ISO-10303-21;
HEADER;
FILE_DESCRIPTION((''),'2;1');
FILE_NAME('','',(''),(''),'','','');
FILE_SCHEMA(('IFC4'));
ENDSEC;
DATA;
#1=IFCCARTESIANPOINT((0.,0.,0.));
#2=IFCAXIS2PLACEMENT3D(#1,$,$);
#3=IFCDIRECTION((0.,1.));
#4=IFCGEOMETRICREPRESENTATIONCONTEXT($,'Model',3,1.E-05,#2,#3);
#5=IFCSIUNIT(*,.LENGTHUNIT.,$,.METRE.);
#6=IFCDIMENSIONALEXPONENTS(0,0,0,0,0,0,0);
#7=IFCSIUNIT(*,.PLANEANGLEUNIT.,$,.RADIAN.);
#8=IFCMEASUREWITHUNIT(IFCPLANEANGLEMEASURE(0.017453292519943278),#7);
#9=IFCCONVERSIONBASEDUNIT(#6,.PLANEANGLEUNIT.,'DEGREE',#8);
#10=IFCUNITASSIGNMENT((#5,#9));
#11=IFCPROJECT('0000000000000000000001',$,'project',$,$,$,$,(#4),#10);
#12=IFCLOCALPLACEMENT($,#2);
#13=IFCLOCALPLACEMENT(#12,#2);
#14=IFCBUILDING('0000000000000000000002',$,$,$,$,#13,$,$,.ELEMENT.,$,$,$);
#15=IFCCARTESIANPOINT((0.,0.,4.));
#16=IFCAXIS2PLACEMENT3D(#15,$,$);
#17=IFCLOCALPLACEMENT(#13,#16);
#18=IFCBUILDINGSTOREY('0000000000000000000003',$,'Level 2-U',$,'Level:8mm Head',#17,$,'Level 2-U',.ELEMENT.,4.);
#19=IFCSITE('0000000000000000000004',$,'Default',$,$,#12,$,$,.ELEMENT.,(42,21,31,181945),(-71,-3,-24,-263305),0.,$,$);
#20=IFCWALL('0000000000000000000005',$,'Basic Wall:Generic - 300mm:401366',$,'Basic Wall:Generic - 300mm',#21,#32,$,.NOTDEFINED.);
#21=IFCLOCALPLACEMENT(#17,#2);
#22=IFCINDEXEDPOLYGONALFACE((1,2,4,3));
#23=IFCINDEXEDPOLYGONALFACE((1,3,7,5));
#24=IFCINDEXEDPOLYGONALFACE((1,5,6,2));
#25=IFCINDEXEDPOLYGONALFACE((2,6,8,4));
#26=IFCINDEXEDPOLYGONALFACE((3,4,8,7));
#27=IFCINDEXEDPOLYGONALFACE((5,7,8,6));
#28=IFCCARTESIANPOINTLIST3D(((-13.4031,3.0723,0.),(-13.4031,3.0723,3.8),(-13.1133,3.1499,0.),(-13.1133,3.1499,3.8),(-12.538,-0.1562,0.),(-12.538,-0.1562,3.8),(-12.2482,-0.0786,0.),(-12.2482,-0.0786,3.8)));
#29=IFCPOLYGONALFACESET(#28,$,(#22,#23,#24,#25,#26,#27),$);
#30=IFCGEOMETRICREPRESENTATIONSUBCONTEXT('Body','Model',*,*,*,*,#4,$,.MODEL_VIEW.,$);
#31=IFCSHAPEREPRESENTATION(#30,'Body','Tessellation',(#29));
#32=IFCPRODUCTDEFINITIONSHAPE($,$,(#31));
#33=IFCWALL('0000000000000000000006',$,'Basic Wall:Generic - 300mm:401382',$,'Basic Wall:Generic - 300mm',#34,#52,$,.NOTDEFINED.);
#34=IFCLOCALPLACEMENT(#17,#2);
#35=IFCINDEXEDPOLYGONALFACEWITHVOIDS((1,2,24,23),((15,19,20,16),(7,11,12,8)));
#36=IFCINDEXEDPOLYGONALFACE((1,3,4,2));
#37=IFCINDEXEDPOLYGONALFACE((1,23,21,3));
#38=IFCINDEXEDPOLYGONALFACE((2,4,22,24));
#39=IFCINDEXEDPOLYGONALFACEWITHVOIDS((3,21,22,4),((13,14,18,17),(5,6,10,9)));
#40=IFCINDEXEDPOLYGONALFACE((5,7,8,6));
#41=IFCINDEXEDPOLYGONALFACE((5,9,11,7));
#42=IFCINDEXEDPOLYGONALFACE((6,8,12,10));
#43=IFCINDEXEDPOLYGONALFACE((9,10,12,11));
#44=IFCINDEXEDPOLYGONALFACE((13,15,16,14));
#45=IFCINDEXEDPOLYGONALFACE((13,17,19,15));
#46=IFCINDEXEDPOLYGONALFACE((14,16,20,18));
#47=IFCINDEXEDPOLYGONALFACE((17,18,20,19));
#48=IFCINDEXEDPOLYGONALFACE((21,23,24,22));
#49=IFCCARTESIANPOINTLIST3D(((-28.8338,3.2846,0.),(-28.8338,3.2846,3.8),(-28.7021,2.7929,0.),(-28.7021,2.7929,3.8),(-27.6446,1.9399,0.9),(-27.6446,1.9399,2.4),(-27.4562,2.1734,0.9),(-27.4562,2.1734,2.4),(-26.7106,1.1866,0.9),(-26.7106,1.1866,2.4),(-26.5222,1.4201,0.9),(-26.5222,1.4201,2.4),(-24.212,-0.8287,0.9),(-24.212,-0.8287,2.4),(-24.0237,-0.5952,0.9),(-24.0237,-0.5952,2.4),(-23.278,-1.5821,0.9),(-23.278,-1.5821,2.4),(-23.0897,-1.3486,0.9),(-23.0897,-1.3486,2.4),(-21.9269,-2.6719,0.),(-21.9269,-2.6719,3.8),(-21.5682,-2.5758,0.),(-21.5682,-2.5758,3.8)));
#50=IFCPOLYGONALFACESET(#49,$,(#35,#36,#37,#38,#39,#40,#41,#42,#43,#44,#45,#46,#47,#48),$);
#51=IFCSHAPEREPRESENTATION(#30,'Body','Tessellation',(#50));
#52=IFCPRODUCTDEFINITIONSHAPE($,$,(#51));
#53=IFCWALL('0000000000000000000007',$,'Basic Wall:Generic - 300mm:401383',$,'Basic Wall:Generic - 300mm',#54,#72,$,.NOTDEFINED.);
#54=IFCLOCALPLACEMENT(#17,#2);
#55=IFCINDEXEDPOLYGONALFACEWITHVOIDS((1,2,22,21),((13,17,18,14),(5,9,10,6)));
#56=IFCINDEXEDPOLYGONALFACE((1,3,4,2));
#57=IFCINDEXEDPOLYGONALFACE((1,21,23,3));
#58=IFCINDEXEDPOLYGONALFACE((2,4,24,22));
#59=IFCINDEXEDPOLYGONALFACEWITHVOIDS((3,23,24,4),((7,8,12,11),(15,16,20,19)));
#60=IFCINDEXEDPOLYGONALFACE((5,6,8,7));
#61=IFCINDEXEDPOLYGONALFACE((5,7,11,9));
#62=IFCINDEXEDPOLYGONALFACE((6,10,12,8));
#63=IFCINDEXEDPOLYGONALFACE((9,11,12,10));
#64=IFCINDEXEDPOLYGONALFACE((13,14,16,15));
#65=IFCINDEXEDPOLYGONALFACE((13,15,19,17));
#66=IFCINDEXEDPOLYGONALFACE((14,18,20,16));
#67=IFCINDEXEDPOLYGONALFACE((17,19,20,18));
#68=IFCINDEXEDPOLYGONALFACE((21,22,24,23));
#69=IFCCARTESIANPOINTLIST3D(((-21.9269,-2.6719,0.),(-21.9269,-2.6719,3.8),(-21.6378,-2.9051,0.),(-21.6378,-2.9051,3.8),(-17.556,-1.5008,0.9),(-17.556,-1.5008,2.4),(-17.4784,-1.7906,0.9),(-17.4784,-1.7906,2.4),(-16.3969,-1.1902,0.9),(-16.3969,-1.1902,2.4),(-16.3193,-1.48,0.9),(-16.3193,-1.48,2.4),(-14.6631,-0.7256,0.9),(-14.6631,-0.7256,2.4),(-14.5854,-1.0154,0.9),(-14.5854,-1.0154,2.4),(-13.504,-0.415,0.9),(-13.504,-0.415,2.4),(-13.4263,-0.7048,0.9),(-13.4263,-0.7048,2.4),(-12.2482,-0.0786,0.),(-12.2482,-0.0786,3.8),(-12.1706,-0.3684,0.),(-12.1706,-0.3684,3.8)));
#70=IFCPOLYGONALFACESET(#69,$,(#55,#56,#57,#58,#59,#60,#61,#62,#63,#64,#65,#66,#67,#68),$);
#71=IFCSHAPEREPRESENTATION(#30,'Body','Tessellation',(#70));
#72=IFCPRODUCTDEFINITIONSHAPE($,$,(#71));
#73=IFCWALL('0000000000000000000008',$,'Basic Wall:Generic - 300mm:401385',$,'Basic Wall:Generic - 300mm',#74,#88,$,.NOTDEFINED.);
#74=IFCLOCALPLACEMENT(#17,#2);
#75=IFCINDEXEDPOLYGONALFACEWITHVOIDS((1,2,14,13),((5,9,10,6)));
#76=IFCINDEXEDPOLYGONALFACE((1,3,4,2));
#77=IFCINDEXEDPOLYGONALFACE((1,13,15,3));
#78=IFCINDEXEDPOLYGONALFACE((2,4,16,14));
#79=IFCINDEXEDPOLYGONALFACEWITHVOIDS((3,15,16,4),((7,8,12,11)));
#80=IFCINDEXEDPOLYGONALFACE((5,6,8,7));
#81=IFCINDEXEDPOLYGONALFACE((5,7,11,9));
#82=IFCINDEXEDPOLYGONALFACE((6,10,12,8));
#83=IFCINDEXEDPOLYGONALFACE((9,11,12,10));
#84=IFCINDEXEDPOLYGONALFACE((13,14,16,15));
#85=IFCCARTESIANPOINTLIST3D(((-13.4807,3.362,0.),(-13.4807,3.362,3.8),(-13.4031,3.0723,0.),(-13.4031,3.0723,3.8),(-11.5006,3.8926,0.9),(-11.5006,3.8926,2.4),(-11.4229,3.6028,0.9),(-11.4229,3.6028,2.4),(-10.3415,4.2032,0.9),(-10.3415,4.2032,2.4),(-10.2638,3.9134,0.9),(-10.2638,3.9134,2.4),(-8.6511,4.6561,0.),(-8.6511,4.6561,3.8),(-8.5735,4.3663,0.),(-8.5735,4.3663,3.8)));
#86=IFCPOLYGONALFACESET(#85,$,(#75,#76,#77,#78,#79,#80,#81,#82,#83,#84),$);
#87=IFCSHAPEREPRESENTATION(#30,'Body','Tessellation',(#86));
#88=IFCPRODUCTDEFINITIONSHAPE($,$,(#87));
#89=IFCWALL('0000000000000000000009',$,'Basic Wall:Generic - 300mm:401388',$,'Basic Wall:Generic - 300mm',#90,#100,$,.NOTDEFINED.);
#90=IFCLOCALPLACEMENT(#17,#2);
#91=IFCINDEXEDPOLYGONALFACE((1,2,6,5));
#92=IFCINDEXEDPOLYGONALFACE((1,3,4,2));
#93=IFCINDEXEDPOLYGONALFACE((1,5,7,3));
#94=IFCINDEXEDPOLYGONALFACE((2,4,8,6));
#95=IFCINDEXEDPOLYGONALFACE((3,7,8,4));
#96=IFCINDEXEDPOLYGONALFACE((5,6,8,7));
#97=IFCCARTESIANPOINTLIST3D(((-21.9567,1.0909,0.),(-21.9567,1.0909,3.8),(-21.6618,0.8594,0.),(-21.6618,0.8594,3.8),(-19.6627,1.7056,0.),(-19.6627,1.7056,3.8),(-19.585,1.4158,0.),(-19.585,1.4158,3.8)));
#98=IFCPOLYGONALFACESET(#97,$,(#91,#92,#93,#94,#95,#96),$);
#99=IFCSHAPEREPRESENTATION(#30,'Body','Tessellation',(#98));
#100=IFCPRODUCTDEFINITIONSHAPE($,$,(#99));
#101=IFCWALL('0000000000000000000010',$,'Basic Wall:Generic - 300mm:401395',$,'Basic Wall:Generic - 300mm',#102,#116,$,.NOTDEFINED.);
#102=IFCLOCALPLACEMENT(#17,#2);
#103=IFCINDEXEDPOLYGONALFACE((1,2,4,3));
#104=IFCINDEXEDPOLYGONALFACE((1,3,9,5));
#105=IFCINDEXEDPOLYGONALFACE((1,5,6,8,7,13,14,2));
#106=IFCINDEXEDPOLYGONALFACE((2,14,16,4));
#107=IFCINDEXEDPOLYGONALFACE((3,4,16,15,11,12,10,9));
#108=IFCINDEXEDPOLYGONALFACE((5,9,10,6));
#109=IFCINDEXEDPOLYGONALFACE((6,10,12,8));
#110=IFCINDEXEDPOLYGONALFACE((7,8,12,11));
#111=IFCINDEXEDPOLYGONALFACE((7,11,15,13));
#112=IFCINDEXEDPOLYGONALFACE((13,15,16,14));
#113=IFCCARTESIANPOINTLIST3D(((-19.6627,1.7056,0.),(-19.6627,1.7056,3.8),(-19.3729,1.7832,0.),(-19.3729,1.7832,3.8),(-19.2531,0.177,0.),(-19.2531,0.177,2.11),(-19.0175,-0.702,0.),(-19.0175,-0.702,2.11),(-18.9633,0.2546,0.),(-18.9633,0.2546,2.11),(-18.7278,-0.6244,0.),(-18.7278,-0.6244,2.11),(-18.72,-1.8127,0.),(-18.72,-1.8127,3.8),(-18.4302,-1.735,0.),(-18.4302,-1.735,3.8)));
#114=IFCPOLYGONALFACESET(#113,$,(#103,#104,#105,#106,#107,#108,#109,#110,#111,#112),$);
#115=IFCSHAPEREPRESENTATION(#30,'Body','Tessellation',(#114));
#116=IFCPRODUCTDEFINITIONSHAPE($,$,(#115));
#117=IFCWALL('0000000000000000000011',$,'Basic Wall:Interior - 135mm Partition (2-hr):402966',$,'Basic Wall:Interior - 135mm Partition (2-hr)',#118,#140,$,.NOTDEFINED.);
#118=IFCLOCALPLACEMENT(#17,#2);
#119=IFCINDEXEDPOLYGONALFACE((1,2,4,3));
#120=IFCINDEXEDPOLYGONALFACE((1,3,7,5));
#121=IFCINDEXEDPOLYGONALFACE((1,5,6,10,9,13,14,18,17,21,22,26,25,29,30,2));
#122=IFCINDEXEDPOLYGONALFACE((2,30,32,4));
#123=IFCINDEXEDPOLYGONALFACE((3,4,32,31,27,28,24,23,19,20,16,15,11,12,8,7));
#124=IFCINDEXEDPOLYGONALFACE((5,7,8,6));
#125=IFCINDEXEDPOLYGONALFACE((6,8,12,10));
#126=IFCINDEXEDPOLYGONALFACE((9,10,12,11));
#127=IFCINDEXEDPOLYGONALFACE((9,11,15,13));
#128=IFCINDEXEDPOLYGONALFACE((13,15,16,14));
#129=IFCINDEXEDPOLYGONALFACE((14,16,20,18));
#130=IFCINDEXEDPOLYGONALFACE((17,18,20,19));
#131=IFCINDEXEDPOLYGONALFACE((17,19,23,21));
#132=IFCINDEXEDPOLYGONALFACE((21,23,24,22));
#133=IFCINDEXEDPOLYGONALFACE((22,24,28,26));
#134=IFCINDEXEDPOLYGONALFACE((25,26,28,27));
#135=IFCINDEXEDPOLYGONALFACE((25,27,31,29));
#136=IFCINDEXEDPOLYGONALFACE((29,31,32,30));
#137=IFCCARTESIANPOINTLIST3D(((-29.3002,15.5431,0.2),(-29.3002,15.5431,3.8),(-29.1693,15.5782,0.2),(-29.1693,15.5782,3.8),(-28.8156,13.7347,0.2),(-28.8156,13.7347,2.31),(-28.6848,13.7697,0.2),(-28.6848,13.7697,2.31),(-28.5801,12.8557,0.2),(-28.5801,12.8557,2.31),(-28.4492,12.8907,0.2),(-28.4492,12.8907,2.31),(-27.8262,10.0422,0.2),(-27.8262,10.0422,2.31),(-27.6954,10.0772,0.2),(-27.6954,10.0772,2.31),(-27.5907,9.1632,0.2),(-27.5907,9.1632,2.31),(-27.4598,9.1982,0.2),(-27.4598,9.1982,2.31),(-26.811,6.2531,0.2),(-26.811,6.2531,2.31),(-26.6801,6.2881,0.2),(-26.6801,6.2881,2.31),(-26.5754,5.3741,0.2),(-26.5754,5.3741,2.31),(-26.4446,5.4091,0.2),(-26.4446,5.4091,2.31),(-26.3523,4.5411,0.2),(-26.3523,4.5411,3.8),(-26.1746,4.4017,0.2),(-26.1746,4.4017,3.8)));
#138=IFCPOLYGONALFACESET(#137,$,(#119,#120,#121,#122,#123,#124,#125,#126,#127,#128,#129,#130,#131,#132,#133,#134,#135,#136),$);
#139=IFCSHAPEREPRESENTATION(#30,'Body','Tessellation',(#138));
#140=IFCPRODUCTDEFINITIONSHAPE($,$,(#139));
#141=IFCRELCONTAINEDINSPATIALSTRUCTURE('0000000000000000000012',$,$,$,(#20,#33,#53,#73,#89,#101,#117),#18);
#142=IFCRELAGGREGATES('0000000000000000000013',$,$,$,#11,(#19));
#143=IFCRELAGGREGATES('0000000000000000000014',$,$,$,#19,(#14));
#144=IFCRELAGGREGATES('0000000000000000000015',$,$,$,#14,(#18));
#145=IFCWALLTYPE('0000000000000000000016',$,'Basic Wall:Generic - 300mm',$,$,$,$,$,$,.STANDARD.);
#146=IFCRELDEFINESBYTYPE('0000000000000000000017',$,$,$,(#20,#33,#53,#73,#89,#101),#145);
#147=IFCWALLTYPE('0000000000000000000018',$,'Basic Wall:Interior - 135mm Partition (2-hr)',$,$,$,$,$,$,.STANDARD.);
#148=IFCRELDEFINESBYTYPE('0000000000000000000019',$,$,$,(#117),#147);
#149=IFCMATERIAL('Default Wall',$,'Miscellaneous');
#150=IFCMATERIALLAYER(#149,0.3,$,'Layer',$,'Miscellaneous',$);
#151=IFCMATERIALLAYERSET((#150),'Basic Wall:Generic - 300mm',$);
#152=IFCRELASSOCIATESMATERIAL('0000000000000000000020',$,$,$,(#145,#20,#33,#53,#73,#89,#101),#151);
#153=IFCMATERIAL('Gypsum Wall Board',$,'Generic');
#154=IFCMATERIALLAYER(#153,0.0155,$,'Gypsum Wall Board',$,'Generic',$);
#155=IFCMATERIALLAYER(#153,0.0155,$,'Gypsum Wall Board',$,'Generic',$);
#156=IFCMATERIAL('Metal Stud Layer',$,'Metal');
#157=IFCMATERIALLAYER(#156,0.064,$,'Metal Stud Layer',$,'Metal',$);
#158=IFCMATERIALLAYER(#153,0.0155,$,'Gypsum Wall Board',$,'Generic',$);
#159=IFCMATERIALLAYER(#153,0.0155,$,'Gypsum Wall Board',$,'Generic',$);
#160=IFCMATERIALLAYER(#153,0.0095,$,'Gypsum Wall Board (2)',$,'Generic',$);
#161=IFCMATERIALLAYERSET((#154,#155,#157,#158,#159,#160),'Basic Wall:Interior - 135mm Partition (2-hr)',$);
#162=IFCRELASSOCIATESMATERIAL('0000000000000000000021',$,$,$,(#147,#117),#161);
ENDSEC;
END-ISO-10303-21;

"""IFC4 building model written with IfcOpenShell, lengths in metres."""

from ifc_helpers import new_model, entity, si_unit, converted_unit, direction, frame, frame_2d, origin, place, context, subcontext, project, spatial, polyline, rectangle, outline, extrude, material, layer, layer_set, layer_usage, type_object, element, save


model = new_model("IFC4")

# Units and contexts
model_context = context("Model", 3, precision=1e-05, world=origin(), true_north=direction((0.0, 1.0)))
body_context = subcontext(model_context, "Body", "Model", "MODEL_VIEW")
ifc_project = project(units=[si_unit("LENGTHUNIT", "METRE"), converted_unit("PLANEANGLEUNIT", "DEGREE", entity("IfcPlaneAngleMeasure", 0.017453292519943278), si_unit("PLANEANGLEUNIT", "RADIAN"), dimensions=[0, 0, 0, 0, 0, 0, 0])], contexts=[model_context])

# Site, building, storey
site_placement = place(None, origin())
site = spatial("IfcSite", under=ifc_project, at=site_placement, Name="Default", CompositionType="ELEMENT", RefLatitude=(42, 21, 31, 181945), RefLongitude=(-71, -3, -24, -263305), RefElevation=0.0)
building_placement = place(site_placement, origin())
building = spatial("IfcBuilding", under=site, at=building_placement, CompositionType="ELEMENT")
storey_placement = place(building_placement, frame((0.0, 0.0, 4.0)))
storey = spatial("IfcBuildingStorey", under=building, at=storey_placement, Name="Level 2-U", ObjectType="Level:8mm Head", LongName="Level 2-U", CompositionType="ELEMENT", Elevation=4.0)

# Wall
ifc_material_1 = material(Name="Default Wall", Category="Miscellaneous")
ifc_layer_1 = layer(ifc_material_1, 0.3, Name="Layer", Category="Miscellaneous")
ifc_layer_set_1 = layer_set([ifc_layer_1], Name="Basic Wall:Generic - 300mm")
ifc_layer_usage_1 = layer_usage(ifc_layer_set_1, "AXIS2", "NEGATIVE", 0.15)
wall_type_1 = type_object("IfcWallType", Name="Basic Wall:Generic - 300mm", PredefinedType="STANDARD", material=ifc_layer_set_1)
wall_1_placement = place(storey_placement, frame((-13.2582, 3.1111, 0.0), z_axis=(0.0, 0.0, 1.0), x_axis=(0.258819, -0.965926, 0.0)))
element("IfcWall", 1, at=wall_1_placement, inside=storey, type_object=wall_type_1, material=ifc_layer_usage_1, Name="Basic Wall:Generic - 300mm:401366", ObjectType="Basic Wall:Generic - 300mm", PredefinedType="NOTDEFINED", context=body_context, shape_type="SweptSolid", body=[
    extrude(rectangle(XDim=3.3424, YDim=0.3, at=frame_2d((1.6712, 0.0), x_axis=(-1.0, 0.0))), origin(), (0.0, 0.0, 1.0), 3.8),
])

# Walls, openings
wall_2_placement = place(storey_placement, frame((-28.928, 3.1679, 0.0), z_axis=(0.0, 0.0, 1.0), x_axis=(0.778359, -0.62782, 0.0)))
wall_2 = element("IfcWall", 2, at=wall_2_placement, inside=storey, type_object=wall_type_1, material=ifc_layer_usage_1, Name="Basic Wall:Generic - 300mm:401382", ObjectType="Basic Wall:Generic - 300mm", PredefinedType="NOTDEFINED", context=body_context, shape_type="SweptSolid", body=[
    extrude(outline(polyline([(9.1158, -0.15), (9.3346, 0.15), (0.0, 0.15), (0.4112, -0.15), (9.1158, -0.15)])), origin(), (0.0, 0.0, 1.0), 3.8),
])
opening_1_placement = place(wall_2_placement, frame((2.9699, 0.15, 0.9)))
element("IfcOpeningElement", 3, at=opening_1_placement, cuts=wall_2, PredefinedType="OPENING", context=body_context, shape_type="SweptSolid", body=[
    extrude(rectangle(XDim=1.5, YDim=1.2, at=frame_2d((0.75, 0.6), x_axis=(-1.0, 0.0))), frame((0.0, 0.0, 0.0), z_axis=(0.0, -1.0, 0.0), x_axis=(0.0, 0.0, 1.0)), (0.0, 0.0, 1.0), 0.3),
])
opening_2_placement = place(wall_2_placement, frame((7.3799, 0.15, 0.9)))
element("IfcOpeningElement", 4, at=opening_2_placement, cuts=wall_2, PredefinedType="OPENING", context=body_context, shape_type="SweptSolid", body=[
    extrude(rectangle(XDim=1.5, YDim=1.2, at=frame_2d((0.75, 0.6), x_axis=(-1.0, 0.0))), frame((0.0, 0.0, 0.0), z_axis=(0.0, -1.0, 0.0), x_axis=(0.0, 0.0, 1.0)), (0.0, 0.0, 1.0), 0.3),
])
wall_3_placement = place(storey_placement, frame((-21.888, -2.8168, 0.0), z_axis=(0.0, 0.0, 1.0), x_axis=(0.965926, 0.258819, 0.0)))
wall_3 = element("IfcWall", 5, at=wall_3_placement, inside=storey, type_object=wall_type_1, material=ifc_layer_usage_1, Name="Basic Wall:Generic - 300mm:401383", ObjectType="Basic Wall:Generic - 300mm", PredefinedType="NOTDEFINED", context=body_context, shape_type="SweptSolid", body=[
    extrude(outline(polyline([(10.02, -0.15), (10.02, 0.15), (9.72, 0.15), (3.62, 0.15), (3.32, 0.15), (0.3713, 0.15), (0.0, 0.15), (0.2188, -0.15), (10.02, -0.15)])), origin(), (0.0, 0.0, 1.0), 3.8),
])
opening_3_placement = place(wall_3_placement, frame((5.725, 0.15, 0.9)))
element("IfcOpeningElement", 6, at=opening_3_placement, cuts=wall_3, PredefinedType="OPENING", context=body_context, shape_type="SweptSolid", body=[
    extrude(rectangle(XDim=1.5, YDim=1.2, at=frame_2d((0.75, 0.6), x_axis=(-1.0, 0.0))), frame((0.0, 0.0, 0.0), z_axis=(0.0, -1.0, 0.0), x_axis=(0.0, 0.0, 1.0)), (0.0, 0.0, 1.0), 0.3),
])
opening_4_placement = place(wall_3_placement, frame((8.72, 0.15, 0.9)))
element("IfcOpeningElement", 7, at=opening_4_placement, cuts=wall_3, PredefinedType="OPENING", context=body_context, shape_type="SweptSolid", body=[
    extrude(rectangle(XDim=1.5, YDim=1.2, at=frame_2d((0.75, 0.6), x_axis=(-1.0, 0.0))), frame((0.0, 0.0, 0.0), z_axis=(0.0, -1.0, 0.0), x_axis=(0.0, 0.0, 1.0)), (0.0, 0.0, 1.0), 0.3),
])

# Wall, opening
wall_4_placement = place(storey_placement, frame((-13.4419, 3.2171, 0.0), z_axis=(0.0, 0.0, 1.0), x_axis=(0.965926, 0.258819, 0.0)))
wall_4 = element("IfcWall", 8, at=wall_4_placement, inside=storey, type_object=wall_type_1, material=ifc_layer_usage_1, Name="Basic Wall:Generic - 300mm:401385", ObjectType="Basic Wall:Generic - 300mm", PredefinedType="NOTDEFINED", context=body_context, shape_type="SweptSolid", body=[
    extrude(rectangle(XDim=5.0, YDim=0.3, at=frame_2d((2.5, 0.0), x_axis=(-1.0, 0.0))), origin(), (0.0, 0.0, 1.0), 3.8),
])
opening_5_placement = place(wall_4_placement, frame((3.25, 0.15, 0.9)))
element("IfcOpeningElement", 9, at=opening_5_placement, cuts=wall_4, PredefinedType="OPENING", context=body_context, shape_type="SweptSolid", body=[
    extrude(rectangle(XDim=1.5, YDim=1.2, at=frame_2d((0.75, 0.6), x_axis=(-1.0, 0.0))), frame((0.0, 0.0, 0.0), z_axis=(0.0, -1.0, 0.0), x_axis=(0.0, 0.0, 1.0)), (0.0, 0.0, 1.0), 0.3),
])

# Wall
wall_5_placement = place(storey_placement, frame((-19.6238, 1.5607, 0.0), z_axis=(0.0, 0.0, 1.0), x_axis=(-0.965926, -0.258819, 0.0)))
element("IfcWall", 10, at=wall_5_placement, inside=storey, type_object=wall_type_1, material=ifc_layer_usage_1, Name="Basic Wall:Generic - 300mm:401388", ObjectType="Basic Wall:Generic - 300mm", PredefinedType="NOTDEFINED", context=body_context, shape_type="SweptSolid", body=[
    extrude(outline(polyline([(2.375, -0.15), (2.15, 0.15), (0.0, 0.15), (0.0, -0.15), (2.375, -0.15)])), origin(), (0.0, 0.0, 1.0), 3.8),
])

# Wall, opening
wall_6_placement = place(storey_placement, frame((-19.5178, 1.7444, 0.0), z_axis=(0.0, 0.0, 1.0), x_axis=(0.258819, -0.965926, 0.0)))
wall_6 = element("IfcWall", 11, at=wall_6_placement, inside=storey, type_object=wall_type_1, material=ifc_layer_usage_1, Name="Basic Wall:Generic - 300mm:401395", ObjectType="Basic Wall:Generic - 300mm", PredefinedType="NOTDEFINED", context=body_context, shape_type="SweptSolid", body=[
    extrude(rectangle(XDim=3.6424, YDim=0.3, at=frame_2d((1.8212, 0.0), x_axis=(-1.0, 0.0))), origin(), (0.0, 0.0, 1.0), 3.8),
])
opening_6_placement = place(wall_6_placement, frame((1.5826, -0.15, 0.0)))
element("IfcOpeningElement", 12, at=opening_6_placement, cuts=wall_6, PredefinedType="OPENING", context=body_context, shape_type="SweptSolid", body=[
    extrude(rectangle(XDim=2.11, YDim=0.91, at=frame_2d((1.055, 0.455), x_axis=(1.0, 0.0))), frame((0.0, 0.0, 0.0), z_axis=(0.0, 1.0, 0.0), x_axis=(0.0, 0.0, 1.0)), (0.0, 0.0, 1.0), 0.3),
])

# Wall, openings
ifc_material_2 = material(Name="Gypsum Wall Board", Category="Generic")
ifc_layer_2 = layer(ifc_material_2, 0.0155, Name="Gypsum Wall Board", Category="Generic")
ifc_layer_3 = layer(ifc_material_2, 0.0155, Name="Gypsum Wall Board", Category="Generic")
ifc_material_3 = material(Name="Metal Stud Layer", Category="Metal")
ifc_layer_4 = layer(ifc_material_3, 0.064, Name="Metal Stud Layer", Category="Metal")
ifc_layer_5 = layer(ifc_material_2, 0.0155, Name="Gypsum Wall Board", Category="Generic")
ifc_layer_6 = layer(ifc_material_2, 0.0155, Name="Gypsum Wall Board", Category="Generic")
ifc_layer_7 = layer(ifc_material_2, 0.0095, Name="Gypsum Wall Board (2)", Category="Generic")
ifc_layer_set_2 = layer_set([ifc_layer_2, ifc_layer_3, ifc_layer_4, ifc_layer_5, ifc_layer_6, ifc_layer_7], Name="Basic Wall:Interior - 135mm Partition (2-hr)")
ifc_layer_usage_2 = layer_usage(ifc_layer_set_2, "AXIS2", "NEGATIVE", 0.0677)
wall_type_2 = type_object("IfcWallType", Name="Basic Wall:Interior - 135mm Partition (2-hr)", PredefinedType="STANDARD", material=ifc_layer_set_2)
wall_7_placement = place(storey_placement, frame((-26.2401, 4.3842, 0.2), z_axis=(0.0, 0.0, 1.0), x_axis=(-0.258819, 0.965926, 0.0)))
wall_7 = element("IfcWall", 13, at=wall_7_placement, inside=storey, type_object=wall_type_2, material=ifc_layer_usage_2, Name="Basic Wall:Interior - 135mm Partition (2-hr):402966", ObjectType="Basic Wall:Interior - 135mm Partition (2-hr)", PredefinedType="NOTDEFINED", context=body_context, shape_type="SweptSolid", body=[
    extrude(outline(polyline([(0.0, -0.0677), (11.5707, -0.0677), (11.5707, 0.0678), (7.4885, 0.0678), (7.353, 0.0678), (2.8158, 0.0678), (2.6803, 0.0678), (0.1807, 0.0678), (0.0, -0.0677)])), origin(), (0.0, 0.0, 1.0), 3.6),
])
opening_7_placement = place(wall_7_placement, frame((9.6985, 0.0677, 0.0)))
element("IfcOpeningElement", 14, at=opening_7_placement, cuts=wall_7, PredefinedType="OPENING", context=body_context, shape_type="SweptSolid", body=[
    extrude(rectangle(XDim=2.11, YDim=0.91, at=frame_2d((1.055, 0.455), x_axis=(1.0, 0.0))), frame((0.0, 0.0, 0.0), z_axis=(0.0, -1.0, 0.0), x_axis=(0.0, 0.0, 1.0)), (0.0, 0.0, 1.0), 0.1355),
])
opening_8_placement = place(wall_7_placement, frame((5.8757, 0.0677, 0.0)))
element("IfcOpeningElement", 15, at=opening_8_placement, cuts=wall_7, PredefinedType="OPENING", context=body_context, shape_type="SweptSolid", body=[
    extrude(rectangle(XDim=2.11, YDim=0.91, at=frame_2d((1.055, 0.455), x_axis=(1.0, 0.0))), frame((0.0, 0.0, 0.0), z_axis=(0.0, -1.0, 0.0), x_axis=(0.0, 0.0, 1.0)), (0.0, 0.0, 1.0), 0.1355),
])
opening_9_placement = place(wall_7_placement, frame((1.953, 0.0677, 0.0)))
element("IfcOpeningElement", 16, at=opening_9_placement, cuts=wall_7, PredefinedType="OPENING", context=body_context, shape_type="SweptSolid", body=[
    extrude(rectangle(XDim=2.11, YDim=0.91, at=frame_2d((1.055, 0.455), x_axis=(1.0, 0.0))), frame((0.0, 0.0, 0.0), z_axis=(0.0, -1.0, 0.0), x_axis=(0.0, 0.0, 1.0)), (0.0, 0.0, 1.0), 0.1355),
])

save(model, "model.ifc")
